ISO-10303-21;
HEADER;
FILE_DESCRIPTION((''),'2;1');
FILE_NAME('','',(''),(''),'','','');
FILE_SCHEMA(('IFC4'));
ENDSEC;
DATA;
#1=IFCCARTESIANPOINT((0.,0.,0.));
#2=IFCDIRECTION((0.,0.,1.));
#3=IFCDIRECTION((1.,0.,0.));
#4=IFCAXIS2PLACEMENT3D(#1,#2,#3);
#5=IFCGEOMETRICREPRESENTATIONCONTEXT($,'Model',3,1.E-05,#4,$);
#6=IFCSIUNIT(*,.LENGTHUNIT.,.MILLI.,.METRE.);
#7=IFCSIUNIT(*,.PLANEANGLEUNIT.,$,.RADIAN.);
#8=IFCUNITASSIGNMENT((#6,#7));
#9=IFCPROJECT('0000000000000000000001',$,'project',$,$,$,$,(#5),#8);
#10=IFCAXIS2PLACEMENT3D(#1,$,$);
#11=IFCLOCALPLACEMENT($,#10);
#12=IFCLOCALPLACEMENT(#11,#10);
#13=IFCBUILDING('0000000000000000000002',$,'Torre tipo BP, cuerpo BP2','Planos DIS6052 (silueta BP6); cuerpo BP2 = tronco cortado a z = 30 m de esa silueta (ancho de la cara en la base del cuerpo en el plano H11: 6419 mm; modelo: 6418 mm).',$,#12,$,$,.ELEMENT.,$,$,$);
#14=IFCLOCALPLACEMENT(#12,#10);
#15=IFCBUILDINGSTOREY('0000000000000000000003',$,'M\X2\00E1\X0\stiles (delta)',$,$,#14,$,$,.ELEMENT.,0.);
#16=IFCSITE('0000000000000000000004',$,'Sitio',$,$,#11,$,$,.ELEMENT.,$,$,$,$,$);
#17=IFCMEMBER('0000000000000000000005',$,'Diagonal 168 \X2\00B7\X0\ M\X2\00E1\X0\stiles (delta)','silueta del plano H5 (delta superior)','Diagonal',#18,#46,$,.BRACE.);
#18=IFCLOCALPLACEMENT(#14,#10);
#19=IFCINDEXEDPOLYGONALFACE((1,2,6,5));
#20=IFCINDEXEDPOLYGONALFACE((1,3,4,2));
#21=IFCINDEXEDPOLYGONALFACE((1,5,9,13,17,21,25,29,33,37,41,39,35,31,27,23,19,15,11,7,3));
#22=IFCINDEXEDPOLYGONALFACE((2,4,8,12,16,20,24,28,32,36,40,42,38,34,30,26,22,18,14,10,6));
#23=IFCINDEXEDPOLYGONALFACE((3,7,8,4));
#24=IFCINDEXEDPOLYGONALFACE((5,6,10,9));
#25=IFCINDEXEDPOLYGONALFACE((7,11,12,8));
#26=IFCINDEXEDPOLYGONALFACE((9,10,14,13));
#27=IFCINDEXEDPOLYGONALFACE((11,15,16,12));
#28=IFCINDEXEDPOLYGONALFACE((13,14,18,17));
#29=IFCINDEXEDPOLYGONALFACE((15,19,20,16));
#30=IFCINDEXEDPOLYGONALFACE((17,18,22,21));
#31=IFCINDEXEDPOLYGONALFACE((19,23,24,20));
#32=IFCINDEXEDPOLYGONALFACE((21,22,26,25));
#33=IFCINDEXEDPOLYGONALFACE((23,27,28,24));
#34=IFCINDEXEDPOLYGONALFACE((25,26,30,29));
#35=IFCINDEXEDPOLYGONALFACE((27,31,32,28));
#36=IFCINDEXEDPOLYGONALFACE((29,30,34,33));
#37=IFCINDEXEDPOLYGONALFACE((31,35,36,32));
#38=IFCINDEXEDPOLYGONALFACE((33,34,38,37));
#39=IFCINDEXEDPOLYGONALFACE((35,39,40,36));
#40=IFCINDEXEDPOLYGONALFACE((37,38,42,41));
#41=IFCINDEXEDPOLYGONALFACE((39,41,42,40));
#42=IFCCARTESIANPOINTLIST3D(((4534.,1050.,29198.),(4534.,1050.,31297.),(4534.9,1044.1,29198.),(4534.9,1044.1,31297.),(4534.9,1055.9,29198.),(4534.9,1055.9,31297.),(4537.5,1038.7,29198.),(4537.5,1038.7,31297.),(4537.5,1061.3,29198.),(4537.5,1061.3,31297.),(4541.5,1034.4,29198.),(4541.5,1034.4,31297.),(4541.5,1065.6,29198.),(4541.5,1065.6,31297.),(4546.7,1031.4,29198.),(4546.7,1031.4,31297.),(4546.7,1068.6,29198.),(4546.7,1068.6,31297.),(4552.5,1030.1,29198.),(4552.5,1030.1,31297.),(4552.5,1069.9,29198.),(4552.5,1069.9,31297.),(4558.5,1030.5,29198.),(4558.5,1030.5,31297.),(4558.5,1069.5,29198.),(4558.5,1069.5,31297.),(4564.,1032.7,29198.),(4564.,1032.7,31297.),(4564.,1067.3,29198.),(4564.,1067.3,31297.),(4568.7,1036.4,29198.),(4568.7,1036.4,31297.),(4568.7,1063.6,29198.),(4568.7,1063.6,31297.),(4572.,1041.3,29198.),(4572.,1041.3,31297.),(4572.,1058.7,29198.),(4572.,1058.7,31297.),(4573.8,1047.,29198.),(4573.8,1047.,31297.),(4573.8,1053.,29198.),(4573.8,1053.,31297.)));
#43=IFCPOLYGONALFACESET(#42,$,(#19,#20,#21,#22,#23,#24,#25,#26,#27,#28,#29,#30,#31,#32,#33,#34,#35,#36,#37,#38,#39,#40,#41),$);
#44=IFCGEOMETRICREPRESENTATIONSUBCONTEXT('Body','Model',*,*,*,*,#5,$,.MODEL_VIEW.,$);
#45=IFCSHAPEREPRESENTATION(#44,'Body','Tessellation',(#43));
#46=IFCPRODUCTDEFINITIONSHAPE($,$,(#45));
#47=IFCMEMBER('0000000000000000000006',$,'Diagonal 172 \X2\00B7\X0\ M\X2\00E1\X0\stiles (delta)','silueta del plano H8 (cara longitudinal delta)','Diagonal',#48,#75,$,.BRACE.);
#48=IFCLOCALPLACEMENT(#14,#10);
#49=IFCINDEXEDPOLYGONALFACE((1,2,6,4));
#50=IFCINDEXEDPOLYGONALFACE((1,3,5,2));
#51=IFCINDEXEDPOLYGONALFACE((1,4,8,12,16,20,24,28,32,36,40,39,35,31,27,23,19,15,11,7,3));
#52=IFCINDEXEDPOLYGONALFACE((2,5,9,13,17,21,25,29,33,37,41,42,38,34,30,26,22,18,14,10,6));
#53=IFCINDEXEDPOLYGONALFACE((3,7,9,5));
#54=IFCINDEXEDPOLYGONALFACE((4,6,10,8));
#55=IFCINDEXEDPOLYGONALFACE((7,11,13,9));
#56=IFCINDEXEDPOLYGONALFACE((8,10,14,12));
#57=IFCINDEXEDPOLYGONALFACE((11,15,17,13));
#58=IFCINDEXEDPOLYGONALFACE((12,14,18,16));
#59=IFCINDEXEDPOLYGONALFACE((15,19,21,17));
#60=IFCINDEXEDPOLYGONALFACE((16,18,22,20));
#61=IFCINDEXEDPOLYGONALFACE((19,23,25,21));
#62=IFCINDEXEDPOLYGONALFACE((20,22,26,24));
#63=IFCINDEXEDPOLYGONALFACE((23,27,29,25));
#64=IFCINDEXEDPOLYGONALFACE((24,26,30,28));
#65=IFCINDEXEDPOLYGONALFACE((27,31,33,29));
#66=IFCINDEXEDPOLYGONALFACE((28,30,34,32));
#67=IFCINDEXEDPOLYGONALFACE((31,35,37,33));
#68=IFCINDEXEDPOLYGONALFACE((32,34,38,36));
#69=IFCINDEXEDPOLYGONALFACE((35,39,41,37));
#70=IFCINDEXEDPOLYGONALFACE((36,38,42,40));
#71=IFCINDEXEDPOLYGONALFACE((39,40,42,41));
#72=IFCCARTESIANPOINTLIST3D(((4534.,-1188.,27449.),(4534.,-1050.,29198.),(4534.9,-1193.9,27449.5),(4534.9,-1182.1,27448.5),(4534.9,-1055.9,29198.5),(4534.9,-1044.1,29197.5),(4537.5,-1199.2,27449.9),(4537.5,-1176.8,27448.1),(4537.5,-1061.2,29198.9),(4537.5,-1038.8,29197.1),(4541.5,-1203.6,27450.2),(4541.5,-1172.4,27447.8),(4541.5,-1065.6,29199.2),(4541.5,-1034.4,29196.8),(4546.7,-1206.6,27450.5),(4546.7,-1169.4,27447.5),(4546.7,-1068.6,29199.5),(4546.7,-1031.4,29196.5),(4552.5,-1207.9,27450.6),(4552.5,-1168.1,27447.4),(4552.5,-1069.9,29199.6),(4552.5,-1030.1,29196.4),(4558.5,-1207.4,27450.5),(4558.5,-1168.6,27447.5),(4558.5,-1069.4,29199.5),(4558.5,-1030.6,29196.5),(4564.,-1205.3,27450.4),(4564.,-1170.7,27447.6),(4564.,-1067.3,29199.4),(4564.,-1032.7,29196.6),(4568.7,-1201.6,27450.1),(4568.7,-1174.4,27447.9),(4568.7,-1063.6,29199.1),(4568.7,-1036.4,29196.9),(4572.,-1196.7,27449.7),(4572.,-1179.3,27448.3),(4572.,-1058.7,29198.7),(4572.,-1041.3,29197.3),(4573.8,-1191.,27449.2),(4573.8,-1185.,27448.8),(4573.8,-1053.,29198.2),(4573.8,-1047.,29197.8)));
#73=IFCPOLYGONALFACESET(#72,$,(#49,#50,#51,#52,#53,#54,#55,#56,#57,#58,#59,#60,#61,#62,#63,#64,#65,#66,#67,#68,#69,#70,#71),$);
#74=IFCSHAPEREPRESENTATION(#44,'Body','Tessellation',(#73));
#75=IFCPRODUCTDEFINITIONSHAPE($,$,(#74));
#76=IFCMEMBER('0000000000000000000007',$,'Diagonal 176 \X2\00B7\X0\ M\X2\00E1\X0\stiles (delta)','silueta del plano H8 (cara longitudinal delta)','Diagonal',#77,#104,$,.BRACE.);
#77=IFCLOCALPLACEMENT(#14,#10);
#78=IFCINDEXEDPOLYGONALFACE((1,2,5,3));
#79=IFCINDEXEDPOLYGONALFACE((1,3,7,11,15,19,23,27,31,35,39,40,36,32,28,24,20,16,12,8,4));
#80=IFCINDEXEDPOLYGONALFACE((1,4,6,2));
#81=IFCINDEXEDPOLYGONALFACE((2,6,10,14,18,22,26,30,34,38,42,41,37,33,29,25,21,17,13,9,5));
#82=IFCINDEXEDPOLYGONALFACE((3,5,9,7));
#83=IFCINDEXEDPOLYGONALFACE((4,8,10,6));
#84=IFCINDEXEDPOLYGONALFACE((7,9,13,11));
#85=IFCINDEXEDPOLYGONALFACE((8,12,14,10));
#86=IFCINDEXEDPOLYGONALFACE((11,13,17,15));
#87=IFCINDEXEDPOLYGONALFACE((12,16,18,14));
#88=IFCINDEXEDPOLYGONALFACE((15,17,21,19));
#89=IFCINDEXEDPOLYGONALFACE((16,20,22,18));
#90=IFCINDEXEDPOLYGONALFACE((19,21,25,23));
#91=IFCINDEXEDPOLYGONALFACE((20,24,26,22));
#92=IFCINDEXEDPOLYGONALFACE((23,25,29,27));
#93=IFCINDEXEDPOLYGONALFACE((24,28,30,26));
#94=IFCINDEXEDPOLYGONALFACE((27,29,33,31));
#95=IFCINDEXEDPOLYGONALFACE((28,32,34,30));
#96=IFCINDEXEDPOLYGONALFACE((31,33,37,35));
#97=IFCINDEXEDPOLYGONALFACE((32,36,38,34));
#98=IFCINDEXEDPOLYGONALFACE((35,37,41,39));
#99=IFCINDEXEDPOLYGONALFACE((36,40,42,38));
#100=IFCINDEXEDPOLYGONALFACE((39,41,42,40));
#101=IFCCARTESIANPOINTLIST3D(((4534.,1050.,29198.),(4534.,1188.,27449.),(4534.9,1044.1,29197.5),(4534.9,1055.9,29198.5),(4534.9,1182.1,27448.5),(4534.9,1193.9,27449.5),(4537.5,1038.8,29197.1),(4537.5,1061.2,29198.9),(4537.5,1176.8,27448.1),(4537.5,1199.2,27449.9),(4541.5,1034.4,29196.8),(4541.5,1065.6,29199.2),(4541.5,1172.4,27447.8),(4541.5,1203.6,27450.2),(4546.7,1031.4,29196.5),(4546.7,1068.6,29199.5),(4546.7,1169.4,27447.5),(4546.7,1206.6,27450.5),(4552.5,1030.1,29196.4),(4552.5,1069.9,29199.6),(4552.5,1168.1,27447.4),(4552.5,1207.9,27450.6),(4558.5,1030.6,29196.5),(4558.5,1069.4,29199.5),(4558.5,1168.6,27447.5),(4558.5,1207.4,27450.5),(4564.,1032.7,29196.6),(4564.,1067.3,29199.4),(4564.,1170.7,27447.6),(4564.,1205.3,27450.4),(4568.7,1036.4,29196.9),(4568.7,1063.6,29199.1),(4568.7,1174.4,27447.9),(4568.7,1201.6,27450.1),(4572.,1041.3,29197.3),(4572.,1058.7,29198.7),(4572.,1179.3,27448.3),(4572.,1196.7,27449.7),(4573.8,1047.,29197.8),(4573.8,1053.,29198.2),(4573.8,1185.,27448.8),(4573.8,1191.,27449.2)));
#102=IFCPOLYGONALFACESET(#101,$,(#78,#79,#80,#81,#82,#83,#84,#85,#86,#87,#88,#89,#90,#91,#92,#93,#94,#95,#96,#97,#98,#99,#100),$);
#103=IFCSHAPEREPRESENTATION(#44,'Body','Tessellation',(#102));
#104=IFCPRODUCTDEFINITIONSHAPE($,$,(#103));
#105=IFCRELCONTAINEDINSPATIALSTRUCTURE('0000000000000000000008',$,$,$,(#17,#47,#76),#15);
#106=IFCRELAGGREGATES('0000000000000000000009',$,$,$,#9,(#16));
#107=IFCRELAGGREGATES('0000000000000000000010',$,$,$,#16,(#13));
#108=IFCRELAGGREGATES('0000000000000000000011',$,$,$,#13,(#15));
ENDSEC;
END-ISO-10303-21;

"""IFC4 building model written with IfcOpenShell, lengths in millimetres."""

from ifc_helpers import new_model, si_unit, frame, origin, origin_with_axes, place, context, subcontext, project, spatial, circle, extrude, element, save


model = new_model("IFC4")

# Units and contexts
model_context = context("Model", 3, precision=1e-05, world=origin_with_axes())
body_context = subcontext(model_context, "Body", "Model", "MODEL_VIEW")
ifc_project = project(units=[si_unit("LENGTHUNIT", "METRE", prefix="MILLI"), si_unit("PLANEANGLEUNIT", "RADIAN")], contexts=[model_context])

# Site, building, storey
site_placement = place(None, origin())
site = spatial("IfcSite", under=ifc_project, at=site_placement, Name="Sitio", CompositionType="ELEMENT")
building_placement = place(site_placement, origin())
building = spatial("IfcBuilding", under=site, at=building_placement, Name="Torre tipo BP, cuerpo BP2", Description="Planos DIS6052 (silueta BP6); cuerpo BP2 = tronco cortado a z = 30 m de esa silueta (ancho de la cara en la base del cuerpo en el plano H11: 6419 mm; modelo: 6418 mm).", CompositionType="ELEMENT")
storey_placement = place(building_placement, origin())
storey = spatial("IfcBuildingStorey", under=building, at=storey_placement, Name="Mástiles (delta)", CompositionType="ELEMENT", Elevation=0.0)

# Members
for number, where, z_axis, x_axis, name in (
    (1, (4554.0, 1050.0, 31297.0), (0.0, 0.0, -1.0), (-1.0, 0.0, 0.0), "Diagonal 168 · Mástiles (delta)"),
):
    element("IfcMember", number, at=place(storey_placement, frame(where, z_axis=z_axis, x_axis=x_axis)), inside=storey, Name=name, Description="silueta del plano H5 (delta superior)", ObjectType="Diagonal", PredefinedType="BRACE", context=body_context, shape_type="SweptSolid", body=[
        extrude(circle(Radius=20.0), None, (0.0, 0.0, 1.0), 2099.0),
    ])
for number, where, z_axis, x_axis, name in (
    (2, (4554.0, -1050.0, 29198.0), (0.0, -0.078658, -0.996902), (-1.0, 0.0, 0.0), "Diagonal 172 · Mástiles (delta)"),
    (3, (4554.0, 1050.0, 29198.0), (0.0, 0.078658, -0.996902), (-1.0, 0.0, 0.0), "Diagonal 176 · Mástiles (delta)"),
):
    element("IfcMember", number, at=place(storey_placement, frame(where, z_axis=z_axis, x_axis=x_axis)), inside=storey, Name=name, Description="silueta del plano H8 (cara longitudinal delta)", ObjectType="Diagonal", PredefinedType="BRACE", context=body_context, shape_type="SweptSolid", body=[
        extrude(circle(Radius=20.0), None, (0.0, 0.0, 1.0), 1754.4),
    ])

save(model, "model.ifc")
